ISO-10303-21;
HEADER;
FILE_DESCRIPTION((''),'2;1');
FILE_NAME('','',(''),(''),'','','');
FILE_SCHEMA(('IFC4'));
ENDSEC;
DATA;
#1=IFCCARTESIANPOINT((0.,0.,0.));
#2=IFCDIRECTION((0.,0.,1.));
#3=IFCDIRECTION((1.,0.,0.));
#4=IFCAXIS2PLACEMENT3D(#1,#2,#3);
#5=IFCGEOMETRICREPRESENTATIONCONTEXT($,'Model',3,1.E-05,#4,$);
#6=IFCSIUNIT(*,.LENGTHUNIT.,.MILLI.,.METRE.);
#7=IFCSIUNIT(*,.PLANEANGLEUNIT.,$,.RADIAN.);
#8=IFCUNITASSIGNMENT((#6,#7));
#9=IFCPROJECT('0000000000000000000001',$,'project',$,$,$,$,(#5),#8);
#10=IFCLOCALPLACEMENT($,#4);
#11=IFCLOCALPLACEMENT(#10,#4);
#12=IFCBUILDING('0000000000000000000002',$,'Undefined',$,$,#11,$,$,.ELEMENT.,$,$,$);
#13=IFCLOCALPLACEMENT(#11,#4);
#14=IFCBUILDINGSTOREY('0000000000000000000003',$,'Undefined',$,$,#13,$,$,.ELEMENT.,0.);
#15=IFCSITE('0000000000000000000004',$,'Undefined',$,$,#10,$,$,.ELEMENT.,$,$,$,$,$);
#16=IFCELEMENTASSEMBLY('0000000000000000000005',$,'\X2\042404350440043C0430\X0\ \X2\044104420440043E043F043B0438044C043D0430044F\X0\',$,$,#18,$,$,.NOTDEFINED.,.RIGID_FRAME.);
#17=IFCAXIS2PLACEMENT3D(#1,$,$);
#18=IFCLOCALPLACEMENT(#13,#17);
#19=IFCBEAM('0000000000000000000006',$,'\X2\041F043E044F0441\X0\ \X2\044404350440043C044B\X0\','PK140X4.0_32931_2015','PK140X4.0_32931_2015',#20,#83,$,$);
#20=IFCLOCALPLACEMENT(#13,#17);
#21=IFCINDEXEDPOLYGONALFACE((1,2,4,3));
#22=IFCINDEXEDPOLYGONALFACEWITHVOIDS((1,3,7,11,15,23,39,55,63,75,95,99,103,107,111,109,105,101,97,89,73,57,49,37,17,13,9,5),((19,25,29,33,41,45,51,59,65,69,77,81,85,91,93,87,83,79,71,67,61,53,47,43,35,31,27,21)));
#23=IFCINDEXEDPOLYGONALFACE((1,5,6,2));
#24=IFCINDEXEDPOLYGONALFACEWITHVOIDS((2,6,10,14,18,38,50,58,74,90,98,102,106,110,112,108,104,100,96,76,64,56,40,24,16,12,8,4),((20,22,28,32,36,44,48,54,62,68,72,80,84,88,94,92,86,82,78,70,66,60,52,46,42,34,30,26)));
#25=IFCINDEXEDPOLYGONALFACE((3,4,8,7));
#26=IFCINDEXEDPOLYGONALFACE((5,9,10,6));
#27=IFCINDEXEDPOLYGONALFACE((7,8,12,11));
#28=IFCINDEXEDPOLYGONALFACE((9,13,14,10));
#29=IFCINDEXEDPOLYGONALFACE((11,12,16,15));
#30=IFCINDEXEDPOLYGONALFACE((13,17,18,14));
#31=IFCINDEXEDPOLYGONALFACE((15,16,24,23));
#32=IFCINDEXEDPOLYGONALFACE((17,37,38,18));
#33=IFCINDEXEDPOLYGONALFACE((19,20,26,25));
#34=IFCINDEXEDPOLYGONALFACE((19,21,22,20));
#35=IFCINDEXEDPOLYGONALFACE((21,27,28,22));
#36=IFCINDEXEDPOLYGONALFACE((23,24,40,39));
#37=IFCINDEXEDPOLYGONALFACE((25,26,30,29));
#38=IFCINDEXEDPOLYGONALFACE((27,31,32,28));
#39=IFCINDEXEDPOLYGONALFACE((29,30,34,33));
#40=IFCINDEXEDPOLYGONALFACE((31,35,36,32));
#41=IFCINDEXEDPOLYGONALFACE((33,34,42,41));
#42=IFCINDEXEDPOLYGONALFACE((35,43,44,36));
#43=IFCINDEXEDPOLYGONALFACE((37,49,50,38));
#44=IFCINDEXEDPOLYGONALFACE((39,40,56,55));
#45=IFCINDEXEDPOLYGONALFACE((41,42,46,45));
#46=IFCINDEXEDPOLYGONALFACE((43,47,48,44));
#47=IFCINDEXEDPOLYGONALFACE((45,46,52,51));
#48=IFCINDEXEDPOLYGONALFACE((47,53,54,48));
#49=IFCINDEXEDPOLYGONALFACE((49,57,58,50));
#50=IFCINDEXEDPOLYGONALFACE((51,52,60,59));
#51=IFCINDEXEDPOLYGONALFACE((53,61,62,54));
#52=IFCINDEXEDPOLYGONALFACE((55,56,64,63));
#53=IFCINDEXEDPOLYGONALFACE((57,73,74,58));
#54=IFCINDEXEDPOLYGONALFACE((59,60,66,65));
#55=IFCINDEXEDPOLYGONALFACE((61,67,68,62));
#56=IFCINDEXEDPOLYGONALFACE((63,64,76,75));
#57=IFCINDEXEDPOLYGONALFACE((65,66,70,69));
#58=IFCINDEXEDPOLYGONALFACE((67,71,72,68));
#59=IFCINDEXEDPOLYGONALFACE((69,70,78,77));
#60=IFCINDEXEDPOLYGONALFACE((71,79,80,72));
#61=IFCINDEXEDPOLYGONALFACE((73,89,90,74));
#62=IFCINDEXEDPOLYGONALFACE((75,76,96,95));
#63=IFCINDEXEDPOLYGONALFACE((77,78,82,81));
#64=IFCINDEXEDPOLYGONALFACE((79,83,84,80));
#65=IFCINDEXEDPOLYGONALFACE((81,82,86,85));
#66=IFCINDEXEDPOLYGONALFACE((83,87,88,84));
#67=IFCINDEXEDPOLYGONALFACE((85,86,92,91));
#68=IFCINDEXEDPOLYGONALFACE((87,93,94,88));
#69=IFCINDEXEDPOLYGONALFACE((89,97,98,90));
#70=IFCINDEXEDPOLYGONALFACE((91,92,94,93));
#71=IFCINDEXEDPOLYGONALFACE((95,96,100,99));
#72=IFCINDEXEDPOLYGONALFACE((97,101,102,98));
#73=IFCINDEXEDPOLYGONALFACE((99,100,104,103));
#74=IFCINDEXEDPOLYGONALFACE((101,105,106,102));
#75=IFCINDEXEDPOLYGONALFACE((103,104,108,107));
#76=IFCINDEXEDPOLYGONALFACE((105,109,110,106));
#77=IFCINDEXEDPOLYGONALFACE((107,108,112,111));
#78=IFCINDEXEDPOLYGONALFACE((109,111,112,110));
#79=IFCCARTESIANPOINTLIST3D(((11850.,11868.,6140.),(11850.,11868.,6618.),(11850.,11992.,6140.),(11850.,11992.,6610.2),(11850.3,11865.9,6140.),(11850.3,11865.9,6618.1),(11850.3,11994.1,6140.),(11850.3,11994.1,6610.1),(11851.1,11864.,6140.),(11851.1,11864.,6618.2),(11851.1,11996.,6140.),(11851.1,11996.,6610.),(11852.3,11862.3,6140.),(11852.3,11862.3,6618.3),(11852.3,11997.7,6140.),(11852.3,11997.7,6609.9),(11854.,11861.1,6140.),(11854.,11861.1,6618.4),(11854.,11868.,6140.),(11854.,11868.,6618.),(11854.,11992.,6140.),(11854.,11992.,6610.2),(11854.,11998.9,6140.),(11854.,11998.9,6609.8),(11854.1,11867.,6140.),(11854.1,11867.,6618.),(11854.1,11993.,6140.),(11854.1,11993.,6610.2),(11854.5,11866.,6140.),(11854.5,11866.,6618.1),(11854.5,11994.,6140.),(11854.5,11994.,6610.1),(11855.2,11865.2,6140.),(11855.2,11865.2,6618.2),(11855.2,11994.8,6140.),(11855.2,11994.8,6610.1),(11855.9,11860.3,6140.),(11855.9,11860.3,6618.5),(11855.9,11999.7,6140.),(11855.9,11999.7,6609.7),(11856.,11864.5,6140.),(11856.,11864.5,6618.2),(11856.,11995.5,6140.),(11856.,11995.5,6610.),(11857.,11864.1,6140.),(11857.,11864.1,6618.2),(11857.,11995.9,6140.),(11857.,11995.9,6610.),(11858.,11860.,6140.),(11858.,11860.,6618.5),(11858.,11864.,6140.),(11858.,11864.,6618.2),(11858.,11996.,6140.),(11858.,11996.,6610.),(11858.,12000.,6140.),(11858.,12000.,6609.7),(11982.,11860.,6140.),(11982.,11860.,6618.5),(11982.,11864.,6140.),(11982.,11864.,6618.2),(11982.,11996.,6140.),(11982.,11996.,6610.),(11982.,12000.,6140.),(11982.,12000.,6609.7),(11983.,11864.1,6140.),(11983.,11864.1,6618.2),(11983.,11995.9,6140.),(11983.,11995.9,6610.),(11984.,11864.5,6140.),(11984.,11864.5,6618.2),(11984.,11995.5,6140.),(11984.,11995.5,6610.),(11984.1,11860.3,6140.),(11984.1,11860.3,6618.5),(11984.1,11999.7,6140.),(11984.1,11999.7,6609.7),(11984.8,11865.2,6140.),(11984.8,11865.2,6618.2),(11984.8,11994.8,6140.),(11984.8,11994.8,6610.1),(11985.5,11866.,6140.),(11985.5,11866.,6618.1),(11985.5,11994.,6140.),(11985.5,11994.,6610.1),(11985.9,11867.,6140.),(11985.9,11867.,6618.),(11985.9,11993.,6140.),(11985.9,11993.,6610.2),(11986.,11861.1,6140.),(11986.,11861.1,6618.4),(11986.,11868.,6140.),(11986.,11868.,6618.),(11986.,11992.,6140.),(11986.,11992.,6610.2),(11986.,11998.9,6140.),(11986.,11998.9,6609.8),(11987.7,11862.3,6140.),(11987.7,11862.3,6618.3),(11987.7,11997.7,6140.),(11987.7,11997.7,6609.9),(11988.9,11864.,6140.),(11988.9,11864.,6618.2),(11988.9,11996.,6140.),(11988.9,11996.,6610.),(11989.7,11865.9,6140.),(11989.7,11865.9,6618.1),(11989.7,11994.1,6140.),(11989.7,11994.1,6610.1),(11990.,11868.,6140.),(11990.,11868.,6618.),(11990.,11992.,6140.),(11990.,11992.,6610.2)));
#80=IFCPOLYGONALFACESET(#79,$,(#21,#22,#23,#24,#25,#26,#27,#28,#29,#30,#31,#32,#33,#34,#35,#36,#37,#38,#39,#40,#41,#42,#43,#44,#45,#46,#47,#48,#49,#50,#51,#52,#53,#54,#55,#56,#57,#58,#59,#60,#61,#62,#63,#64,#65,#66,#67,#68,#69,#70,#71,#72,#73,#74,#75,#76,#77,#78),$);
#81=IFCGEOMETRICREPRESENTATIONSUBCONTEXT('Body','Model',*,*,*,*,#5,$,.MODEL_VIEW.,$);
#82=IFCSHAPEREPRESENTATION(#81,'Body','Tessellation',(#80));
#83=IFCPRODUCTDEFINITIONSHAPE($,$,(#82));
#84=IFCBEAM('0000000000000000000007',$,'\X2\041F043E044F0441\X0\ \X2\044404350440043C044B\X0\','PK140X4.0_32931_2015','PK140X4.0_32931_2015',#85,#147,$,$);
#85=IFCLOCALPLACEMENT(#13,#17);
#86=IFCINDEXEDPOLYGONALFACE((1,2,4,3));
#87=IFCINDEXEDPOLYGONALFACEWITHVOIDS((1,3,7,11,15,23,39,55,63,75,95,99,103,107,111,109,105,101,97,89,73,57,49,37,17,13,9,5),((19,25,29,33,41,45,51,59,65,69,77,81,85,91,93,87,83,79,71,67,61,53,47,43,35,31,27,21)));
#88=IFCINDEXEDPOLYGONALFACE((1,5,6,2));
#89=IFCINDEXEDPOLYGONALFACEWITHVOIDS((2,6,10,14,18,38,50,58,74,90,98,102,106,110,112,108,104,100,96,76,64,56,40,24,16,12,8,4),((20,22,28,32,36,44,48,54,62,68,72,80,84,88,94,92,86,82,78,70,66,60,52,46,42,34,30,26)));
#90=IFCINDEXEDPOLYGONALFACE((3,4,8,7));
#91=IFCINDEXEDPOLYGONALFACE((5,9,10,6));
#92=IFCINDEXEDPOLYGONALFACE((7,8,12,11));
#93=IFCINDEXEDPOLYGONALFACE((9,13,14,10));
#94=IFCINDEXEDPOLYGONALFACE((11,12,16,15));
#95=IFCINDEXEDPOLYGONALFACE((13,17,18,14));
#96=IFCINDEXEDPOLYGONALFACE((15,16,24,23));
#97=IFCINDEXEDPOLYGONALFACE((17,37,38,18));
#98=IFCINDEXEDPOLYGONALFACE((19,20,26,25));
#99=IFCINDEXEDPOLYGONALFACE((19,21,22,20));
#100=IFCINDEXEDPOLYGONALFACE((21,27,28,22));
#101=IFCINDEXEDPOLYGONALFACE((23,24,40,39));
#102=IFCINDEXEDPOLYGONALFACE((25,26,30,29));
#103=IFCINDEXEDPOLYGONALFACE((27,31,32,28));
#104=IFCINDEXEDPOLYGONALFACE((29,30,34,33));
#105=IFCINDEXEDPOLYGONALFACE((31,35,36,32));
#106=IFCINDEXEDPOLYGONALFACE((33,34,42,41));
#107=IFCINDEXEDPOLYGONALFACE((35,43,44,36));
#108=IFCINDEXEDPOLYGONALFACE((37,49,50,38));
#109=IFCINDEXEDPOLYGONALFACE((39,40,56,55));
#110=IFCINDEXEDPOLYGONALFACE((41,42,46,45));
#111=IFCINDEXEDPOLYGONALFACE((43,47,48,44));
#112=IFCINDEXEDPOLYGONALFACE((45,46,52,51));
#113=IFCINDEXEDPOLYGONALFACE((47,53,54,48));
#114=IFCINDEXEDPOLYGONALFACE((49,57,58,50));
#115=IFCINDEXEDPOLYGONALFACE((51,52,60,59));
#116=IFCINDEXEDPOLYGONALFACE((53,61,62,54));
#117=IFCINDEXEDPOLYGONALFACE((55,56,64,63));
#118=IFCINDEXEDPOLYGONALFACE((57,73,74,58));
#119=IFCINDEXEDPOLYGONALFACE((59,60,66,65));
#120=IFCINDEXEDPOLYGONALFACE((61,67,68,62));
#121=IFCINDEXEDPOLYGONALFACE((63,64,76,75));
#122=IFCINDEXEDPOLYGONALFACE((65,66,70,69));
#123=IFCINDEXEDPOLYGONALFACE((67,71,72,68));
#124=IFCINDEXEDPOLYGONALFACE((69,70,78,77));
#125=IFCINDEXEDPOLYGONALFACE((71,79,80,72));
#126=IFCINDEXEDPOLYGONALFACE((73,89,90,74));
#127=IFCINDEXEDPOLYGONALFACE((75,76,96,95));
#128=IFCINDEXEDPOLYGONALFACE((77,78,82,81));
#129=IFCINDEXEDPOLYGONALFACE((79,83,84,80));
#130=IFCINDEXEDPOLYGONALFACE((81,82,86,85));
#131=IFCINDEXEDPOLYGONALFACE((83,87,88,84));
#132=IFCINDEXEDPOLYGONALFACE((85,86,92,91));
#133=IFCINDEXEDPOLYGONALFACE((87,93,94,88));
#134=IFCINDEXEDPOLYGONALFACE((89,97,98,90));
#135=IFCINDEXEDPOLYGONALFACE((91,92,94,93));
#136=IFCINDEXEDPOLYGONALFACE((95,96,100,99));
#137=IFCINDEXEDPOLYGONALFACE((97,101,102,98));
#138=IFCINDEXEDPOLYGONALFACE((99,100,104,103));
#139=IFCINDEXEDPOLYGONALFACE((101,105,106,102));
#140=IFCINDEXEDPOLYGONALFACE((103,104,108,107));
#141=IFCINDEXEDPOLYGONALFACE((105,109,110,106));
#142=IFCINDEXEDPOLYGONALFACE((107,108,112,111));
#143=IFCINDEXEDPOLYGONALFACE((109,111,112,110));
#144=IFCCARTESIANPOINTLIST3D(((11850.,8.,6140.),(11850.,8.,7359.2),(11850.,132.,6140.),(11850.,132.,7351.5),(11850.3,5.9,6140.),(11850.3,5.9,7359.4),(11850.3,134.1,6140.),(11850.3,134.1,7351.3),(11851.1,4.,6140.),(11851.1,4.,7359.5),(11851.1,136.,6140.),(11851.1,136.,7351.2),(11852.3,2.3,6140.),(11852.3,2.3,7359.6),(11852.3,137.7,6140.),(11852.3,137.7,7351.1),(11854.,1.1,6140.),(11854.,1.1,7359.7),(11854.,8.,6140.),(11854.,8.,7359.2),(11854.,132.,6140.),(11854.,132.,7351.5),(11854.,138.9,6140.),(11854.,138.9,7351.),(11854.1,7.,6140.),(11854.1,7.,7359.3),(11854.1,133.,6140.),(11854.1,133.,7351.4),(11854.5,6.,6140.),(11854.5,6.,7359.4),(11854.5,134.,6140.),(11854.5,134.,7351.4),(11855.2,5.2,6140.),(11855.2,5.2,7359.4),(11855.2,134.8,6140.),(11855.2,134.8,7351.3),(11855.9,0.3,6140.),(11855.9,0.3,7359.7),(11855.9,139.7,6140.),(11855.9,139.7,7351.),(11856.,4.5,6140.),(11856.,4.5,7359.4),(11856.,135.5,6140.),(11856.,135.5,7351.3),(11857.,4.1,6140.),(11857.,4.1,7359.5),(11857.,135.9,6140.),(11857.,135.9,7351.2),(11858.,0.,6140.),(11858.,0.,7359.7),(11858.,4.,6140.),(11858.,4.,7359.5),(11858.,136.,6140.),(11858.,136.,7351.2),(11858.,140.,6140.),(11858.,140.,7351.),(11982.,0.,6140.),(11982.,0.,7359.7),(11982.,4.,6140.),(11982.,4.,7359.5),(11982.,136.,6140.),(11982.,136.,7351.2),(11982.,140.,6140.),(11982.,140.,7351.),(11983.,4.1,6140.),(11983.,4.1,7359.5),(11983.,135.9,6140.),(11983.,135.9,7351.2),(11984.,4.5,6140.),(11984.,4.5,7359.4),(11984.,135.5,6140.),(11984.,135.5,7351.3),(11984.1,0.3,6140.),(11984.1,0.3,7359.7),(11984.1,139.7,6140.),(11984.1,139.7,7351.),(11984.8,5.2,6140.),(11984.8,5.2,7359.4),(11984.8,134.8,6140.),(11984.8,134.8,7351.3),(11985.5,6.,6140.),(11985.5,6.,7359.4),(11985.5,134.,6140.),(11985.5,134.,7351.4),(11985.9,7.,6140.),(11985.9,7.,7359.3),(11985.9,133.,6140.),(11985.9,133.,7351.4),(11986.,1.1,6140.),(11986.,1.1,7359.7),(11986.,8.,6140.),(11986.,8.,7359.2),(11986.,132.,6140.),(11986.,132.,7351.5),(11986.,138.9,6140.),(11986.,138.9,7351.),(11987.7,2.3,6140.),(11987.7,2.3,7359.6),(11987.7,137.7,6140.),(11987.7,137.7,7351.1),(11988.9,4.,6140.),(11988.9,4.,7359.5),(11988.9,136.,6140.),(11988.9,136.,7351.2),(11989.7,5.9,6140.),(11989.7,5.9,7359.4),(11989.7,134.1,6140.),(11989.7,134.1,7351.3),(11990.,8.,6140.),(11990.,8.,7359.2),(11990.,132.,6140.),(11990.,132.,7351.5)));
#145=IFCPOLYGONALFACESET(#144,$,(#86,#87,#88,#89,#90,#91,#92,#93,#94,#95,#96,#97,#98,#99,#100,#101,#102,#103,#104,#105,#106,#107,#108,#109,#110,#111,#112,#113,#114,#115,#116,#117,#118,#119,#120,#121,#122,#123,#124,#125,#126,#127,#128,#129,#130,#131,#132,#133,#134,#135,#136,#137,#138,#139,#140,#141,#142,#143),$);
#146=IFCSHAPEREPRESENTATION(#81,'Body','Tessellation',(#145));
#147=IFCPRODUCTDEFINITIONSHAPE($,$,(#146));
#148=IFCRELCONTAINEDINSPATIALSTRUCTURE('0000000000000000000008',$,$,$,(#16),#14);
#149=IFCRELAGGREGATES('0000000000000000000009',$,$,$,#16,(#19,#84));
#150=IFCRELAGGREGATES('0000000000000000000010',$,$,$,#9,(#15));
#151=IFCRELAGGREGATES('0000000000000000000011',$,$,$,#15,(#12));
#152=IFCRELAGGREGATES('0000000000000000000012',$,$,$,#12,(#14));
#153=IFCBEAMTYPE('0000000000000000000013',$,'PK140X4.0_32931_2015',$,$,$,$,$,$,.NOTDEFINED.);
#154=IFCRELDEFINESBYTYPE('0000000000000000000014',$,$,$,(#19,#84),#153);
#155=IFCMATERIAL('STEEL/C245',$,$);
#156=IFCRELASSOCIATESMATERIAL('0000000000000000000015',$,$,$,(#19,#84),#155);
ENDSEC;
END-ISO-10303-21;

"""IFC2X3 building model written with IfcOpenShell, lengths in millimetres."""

from ifc_helpers import new_model, si_unit, frame, origin_with_axes, origin_2d_with_axis, place, context, subcontext, project, spatial, hollow_rectangle, extrude, clip, halfspace, material, type_object, element, aggregate, save


model = new_model("IFC2X3")

# Units and contexts
model_context = context("Model", 3, precision=1e-05, world=origin_with_axes())
body_context = subcontext(model_context, "Body", "Model", "MODEL_VIEW")
ifc_project = project(units=[si_unit("LENGTHUNIT", "METRE", prefix="MILLI"), si_unit("PLANEANGLEUNIT", "RADIAN")], contexts=[model_context])

# Site, building, storey
site_placement = place(None, origin_with_axes())
site = spatial("IfcSite", under=ifc_project, at=site_placement, Name="Undefined", CompositionType="ELEMENT")
building_placement = place(site_placement, origin_with_axes())
building = spatial("IfcBuilding", under=site, at=building_placement, Name="Undefined", CompositionType="ELEMENT")
storey_placement = place(building_placement, origin_with_axes())
storey = spatial("IfcBuildingStorey", under=building, at=storey_placement, Name="Undefined", CompositionType="ELEMENT", Elevation=0.0)

# Shared definitions
ifc_material = material(Name="STEEL/C245")

# Element assembly, beams
assembly_1_placement = place(storey_placement, origin_with_axes())
assembly_1 = element("IfcElementAssembly", 1, at=assembly_1_placement, inside=storey, Name="Ферма строплиьная", AssemblyPlace="NOTDEFINED", PredefinedType="RIGID_FRAME")
beam_type_1 = type_object("IfcBeamType", Name="PK140X4.0_32931_2015", PredefinedType="NOTDEFINED")
beam_1_placement = place(assembly_1_placement, frame((11920.0, 11930.0, 6609.7), z_axis=(1.0, 0.0, 0.0), x_axis=(0.0, 0.0, -1.0)))
beam_1 = element("IfcBeam", 2, at=beam_1_placement, type_object=beam_type_1, material=ifc_material, Name="Пояс фермы", Description="PK140X4.0_32931_2015", ObjectType="PK140X4.0_32931_2015", context=body_context, shape_type="Clipping", body=[
    clip(extrude(hollow_rectangle(XDim=140.0, YDim=140.0, WallThickness=4.0, InnerFilletRadius=4.0, OuterFilletRadius=8.0, at=origin_2d_with_axis()), frame((469.7, 0.0, 0.0), z_axis=(-1.0, 0.0, 0.0), x_axis=(0.0, -1.0, 0.0)), (0.0, 0.0, 1.0), 478.5), halfspace(frame((-14.9, -167.6, 0.0), z_axis=(-0.998053, 0.062378, 0.0), x_axis=(0.0, 0.0, 1.0)), False)),
])
beam_2_placement = place(assembly_1_placement, frame((11920.0, 70.0, 7359.7), z_axis=(1.0, 0.0, 0.0), x_axis=(0.0, 0.0, -1.0)))
beam_2 = element("IfcBeam", 3, at=beam_2_placement, type_object=beam_type_1, material=ifc_material, Name="Пояс фермы", Description="PK140X4.0_32931_2015", ObjectType="PK140X4.0_32931_2015", context=body_context, shape_type="Clipping", body=[
    clip(extrude(hollow_rectangle(XDim=140.0, YDim=140.0, WallThickness=4.0, InnerFilletRadius=4.0, OuterFilletRadius=8.0, at=origin_2d_with_axis()), frame((1219.7, 0.0, 0.0), z_axis=(-1.0, 0.0, 0.0), x_axis=(0.0, -1.0, 0.0)), (0.0, 0.0, 1.0), 1219.8), halfspace(frame((10.5, 98.4, 0.0), z_axis=(0.998053, -0.062378, 0.0), x_axis=(0.0, 0.0, 1.0)), True)),
])
aggregate(assembly_1, [beam_1, beam_2])

save(model, "model.ifc")
